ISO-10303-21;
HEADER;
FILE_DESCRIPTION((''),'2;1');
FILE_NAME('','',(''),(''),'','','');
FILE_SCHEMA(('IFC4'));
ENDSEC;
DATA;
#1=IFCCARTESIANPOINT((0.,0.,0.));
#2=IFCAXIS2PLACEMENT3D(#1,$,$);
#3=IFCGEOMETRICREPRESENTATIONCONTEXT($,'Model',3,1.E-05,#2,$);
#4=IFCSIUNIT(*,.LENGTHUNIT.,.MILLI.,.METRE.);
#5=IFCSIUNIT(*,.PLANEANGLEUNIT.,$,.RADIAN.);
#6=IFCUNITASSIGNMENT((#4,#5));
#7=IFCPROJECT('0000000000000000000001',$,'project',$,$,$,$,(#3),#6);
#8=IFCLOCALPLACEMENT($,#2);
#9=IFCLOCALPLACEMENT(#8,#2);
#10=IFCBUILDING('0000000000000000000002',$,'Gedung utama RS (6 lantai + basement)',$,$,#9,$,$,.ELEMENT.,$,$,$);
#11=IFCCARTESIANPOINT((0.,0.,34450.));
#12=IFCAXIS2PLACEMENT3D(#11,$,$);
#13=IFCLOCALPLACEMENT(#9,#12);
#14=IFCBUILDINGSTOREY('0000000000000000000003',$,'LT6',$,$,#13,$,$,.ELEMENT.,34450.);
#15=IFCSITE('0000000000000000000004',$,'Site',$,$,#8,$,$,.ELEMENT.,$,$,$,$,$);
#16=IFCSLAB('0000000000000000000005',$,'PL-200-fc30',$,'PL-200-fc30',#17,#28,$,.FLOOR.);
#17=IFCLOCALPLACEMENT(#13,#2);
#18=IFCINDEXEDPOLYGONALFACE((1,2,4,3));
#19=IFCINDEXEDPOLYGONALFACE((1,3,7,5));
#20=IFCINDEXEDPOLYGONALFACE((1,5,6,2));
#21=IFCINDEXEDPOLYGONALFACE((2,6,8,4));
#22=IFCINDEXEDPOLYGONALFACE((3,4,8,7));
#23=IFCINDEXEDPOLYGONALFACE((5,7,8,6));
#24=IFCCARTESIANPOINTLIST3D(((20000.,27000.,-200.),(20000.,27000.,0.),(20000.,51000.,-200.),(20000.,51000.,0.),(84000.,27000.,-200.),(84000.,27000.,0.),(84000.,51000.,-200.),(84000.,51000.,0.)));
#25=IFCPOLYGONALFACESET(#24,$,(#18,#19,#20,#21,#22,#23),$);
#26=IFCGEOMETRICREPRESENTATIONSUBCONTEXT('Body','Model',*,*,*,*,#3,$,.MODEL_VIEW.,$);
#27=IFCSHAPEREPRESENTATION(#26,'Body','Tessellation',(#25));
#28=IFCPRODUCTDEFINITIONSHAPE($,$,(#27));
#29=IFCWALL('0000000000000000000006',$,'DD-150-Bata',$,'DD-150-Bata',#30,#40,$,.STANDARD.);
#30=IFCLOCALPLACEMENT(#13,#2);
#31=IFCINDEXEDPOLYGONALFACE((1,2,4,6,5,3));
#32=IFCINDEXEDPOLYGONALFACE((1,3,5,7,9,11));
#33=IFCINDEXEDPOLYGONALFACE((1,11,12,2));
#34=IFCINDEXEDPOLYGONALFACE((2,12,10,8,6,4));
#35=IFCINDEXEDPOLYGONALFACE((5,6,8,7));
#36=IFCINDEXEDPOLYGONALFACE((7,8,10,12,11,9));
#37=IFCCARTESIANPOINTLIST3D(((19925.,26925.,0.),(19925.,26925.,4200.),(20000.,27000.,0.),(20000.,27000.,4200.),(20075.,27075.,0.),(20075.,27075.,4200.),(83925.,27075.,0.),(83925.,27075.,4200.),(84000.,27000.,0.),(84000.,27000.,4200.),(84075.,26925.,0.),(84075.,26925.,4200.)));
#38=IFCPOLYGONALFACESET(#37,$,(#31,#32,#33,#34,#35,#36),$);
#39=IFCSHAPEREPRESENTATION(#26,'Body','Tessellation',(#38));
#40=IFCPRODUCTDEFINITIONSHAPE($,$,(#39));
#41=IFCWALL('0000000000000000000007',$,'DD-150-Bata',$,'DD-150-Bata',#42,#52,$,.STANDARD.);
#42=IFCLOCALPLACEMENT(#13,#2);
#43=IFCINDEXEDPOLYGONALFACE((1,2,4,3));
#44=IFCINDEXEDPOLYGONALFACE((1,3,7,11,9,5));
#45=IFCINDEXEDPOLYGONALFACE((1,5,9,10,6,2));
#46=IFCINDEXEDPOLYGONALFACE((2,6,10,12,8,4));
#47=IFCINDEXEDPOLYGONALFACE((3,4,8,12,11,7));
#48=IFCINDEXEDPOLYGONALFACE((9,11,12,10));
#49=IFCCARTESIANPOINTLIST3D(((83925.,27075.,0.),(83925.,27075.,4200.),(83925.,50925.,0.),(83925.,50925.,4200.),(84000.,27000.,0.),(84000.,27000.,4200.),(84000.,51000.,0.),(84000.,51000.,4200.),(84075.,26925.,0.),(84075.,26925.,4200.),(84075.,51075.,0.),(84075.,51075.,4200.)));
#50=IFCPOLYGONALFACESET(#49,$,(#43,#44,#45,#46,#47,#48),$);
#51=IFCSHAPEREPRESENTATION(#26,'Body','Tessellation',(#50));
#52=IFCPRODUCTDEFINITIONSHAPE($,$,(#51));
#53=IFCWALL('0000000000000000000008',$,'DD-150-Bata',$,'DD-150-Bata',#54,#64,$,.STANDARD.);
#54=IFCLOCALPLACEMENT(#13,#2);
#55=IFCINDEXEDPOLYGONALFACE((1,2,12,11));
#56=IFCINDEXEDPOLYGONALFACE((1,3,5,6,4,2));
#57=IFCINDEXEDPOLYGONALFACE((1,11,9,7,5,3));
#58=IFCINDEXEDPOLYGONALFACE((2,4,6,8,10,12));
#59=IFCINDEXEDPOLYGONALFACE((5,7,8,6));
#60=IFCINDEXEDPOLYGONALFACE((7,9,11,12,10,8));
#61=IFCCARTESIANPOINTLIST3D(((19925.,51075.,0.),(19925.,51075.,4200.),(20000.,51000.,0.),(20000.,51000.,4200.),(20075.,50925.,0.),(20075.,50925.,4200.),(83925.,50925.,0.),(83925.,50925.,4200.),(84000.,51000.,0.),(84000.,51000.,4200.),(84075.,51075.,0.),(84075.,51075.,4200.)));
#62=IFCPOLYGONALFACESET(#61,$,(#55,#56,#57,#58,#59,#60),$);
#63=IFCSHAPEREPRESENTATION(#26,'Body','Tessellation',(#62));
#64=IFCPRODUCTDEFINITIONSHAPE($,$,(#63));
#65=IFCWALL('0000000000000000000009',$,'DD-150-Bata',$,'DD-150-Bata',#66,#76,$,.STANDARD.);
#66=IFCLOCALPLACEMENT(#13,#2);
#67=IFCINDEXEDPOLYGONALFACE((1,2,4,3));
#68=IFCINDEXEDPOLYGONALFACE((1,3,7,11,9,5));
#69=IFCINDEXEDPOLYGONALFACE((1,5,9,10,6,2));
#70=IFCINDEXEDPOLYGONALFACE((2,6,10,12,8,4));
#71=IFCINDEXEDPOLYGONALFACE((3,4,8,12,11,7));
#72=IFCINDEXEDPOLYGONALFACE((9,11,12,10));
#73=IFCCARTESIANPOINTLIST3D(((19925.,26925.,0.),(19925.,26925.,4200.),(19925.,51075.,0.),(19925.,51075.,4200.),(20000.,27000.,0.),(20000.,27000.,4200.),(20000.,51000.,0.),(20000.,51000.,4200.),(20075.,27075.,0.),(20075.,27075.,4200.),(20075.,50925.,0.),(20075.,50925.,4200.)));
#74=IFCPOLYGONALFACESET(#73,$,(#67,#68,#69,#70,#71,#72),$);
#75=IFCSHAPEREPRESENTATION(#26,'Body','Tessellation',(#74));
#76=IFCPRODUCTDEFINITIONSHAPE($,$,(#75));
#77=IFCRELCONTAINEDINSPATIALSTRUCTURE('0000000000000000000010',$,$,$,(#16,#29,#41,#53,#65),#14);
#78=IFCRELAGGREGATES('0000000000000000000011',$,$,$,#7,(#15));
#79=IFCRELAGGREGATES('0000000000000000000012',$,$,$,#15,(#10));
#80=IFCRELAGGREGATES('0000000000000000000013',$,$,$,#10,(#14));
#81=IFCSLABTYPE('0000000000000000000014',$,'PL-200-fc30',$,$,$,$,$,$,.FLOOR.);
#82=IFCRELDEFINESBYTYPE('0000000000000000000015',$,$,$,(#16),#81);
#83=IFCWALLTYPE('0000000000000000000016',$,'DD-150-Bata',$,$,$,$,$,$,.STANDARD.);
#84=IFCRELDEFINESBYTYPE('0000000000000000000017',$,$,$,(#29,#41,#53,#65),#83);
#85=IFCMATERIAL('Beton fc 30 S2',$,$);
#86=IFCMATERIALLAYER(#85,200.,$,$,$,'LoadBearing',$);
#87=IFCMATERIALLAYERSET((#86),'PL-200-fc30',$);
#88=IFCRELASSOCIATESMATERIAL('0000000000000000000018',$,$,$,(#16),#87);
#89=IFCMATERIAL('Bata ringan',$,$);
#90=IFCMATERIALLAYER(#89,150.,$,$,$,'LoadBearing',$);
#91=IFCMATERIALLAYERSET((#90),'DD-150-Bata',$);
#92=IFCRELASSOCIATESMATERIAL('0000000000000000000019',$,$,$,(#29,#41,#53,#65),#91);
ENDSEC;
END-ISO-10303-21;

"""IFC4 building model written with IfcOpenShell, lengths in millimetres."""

from ifc_helpers import new_model, si_unit, frame, origin, place, context, subcontext, project, spatial, polyline, outline, extrude, material, layer, layer_set, layer_usage, type_object, element, save


model = new_model("IFC4")

# Units and contexts
model_context = context("Model", 3, precision=1e-05, world=origin())
body_context = subcontext(model_context, "Body", "Model", "MODEL_VIEW")
ifc_project = project(units=[si_unit("LENGTHUNIT", "METRE", prefix="MILLI"), si_unit("PLANEANGLEUNIT", "RADIAN")], contexts=[model_context])

# Site, building, storey
site_placement = place(None, origin())
site = spatial("IfcSite", under=ifc_project, at=site_placement, Name="Site", CompositionType="ELEMENT")
building_placement = place(site_placement, origin())
building = spatial("IfcBuilding", under=site, at=building_placement, Name="Gedung utama RS (6 lantai + basement)", CompositionType="ELEMENT")
storey_placement = place(building_placement, frame((0.0, 0.0, 34450.0)))
storey = spatial("IfcBuildingStorey", under=building, at=storey_placement, Name="LT6", CompositionType="ELEMENT", Elevation=34450.0)

# Slab
ifc_material_1 = material(Name="Beton fc 30 S2")
ifc_layer_1 = layer(ifc_material_1, 200.0, Category="LoadBearing")
ifc_layer_set_1 = layer_set([ifc_layer_1], Name="PL-200-fc30")
ifc_layer_usage_1 = layer_usage(ifc_layer_set_1, "AXIS3", "NEGATIVE", 0.0)
slab_type = type_object("IfcSlabType", Name="PL-200-fc30", PredefinedType="FLOOR")
slab_placement = place(storey_placement, origin())
element("IfcSlab", 1, at=slab_placement, inside=storey, type_object=slab_type, material=ifc_layer_usage_1, Name="PL-200-fc30", ObjectType="PL-200-fc30", PredefinedType="FLOOR", context=body_context, shape_type="SweptSolid", body=[
    extrude(outline(polyline([(20000.0, 27000.0), (84000.0, 27000.0), (84000.0, 51000.0), (20000.0, 51000.0), (20000.0, 27000.0)])), frame((0.0, 0.0, -200.0)), (0.0, 0.0, 1.0), 200.0),
])

# Walls
ifc_material_2 = material(Name="Bata ringan")
ifc_layer_2 = layer(ifc_material_2, 150.0, Category="LoadBearing")
ifc_layer_set_2 = layer_set([ifc_layer_2], Name="DD-150-Bata")
ifc_layer_usage_2 = layer_usage(ifc_layer_set_2, "AXIS2", "NEGATIVE", 75.0)
wall_type = type_object("IfcWallType", Name="DD-150-Bata", PredefinedType="STANDARD")
wall_1_placement = place(storey_placement, frame((20000.0, 27000.0, 0.0), z_axis=(0.0, 0.0, 1.0), x_axis=(1.0, 0.0, 0.0)))
element("IfcWall", 2, at=wall_1_placement, inside=storey, type_object=wall_type, material=ifc_layer_usage_2, Name="DD-150-Bata", ObjectType="DD-150-Bata", PredefinedType="STANDARD", context=body_context, shape_type="SweptSolid", body=[
    extrude(outline(polyline([(-75.0, -75.0), (0.0, 0.0), (75.0, 75.0), (63925.0, 75.0), (64000.0, 0.0), (64075.0, -75.0), (-75.0, -75.0)])), origin(), (0.0, 0.0, 1.0), 4200.0),
])
wall_2_placement = place(storey_placement, frame((84000.0, 27000.0, 0.0), z_axis=(0.0, 0.0, 1.0), x_axis=(0.0, 1.0, 0.0)))
element("IfcWall", 3, at=wall_2_placement, inside=storey, type_object=wall_type, material=ifc_layer_usage_2, Name="DD-150-Bata", ObjectType="DD-150-Bata", PredefinedType="STANDARD", context=body_context, shape_type="SweptSolid", body=[
    extrude(outline(polyline([(-75.0, -75.0), (0.0, 0.0), (75.0, 75.0), (23925.0, 75.0), (24000.0, 0.0), (24075.0, -75.0), (-75.0, -75.0)])), origin(), (0.0, 0.0, 1.0), 4200.0),
])
wall_3_placement = place(storey_placement, frame((84000.0, 51000.0, 0.0), z_axis=(0.0, 0.0, 1.0), x_axis=(-1.0, 0.0, 0.0)))
element("IfcWall", 4, at=wall_3_placement, inside=storey, type_object=wall_type, material=ifc_layer_usage_2, Name="DD-150-Bata", ObjectType="DD-150-Bata", PredefinedType="STANDARD", context=body_context, shape_type="SweptSolid", body=[
    extrude(outline(polyline([(-75.0, -75.0), (0.0, 0.0), (75.0, 75.0), (63925.0, 75.0), (64000.0, 0.0), (64075.0, -75.0), (-75.0, -75.0)])), origin(), (0.0, 0.0, 1.0), 4200.0),
])
wall_4_placement = place(storey_placement, frame((20000.0, 51000.0, 0.0), z_axis=(0.0, 0.0, 1.0), x_axis=(0.0, -1.0, 0.0)))
element("IfcWall", 5, at=wall_4_placement, inside=storey, type_object=wall_type, material=ifc_layer_usage_2, Name="DD-150-Bata", ObjectType="DD-150-Bata", PredefinedType="STANDARD", context=body_context, shape_type="SweptSolid", body=[
    extrude(outline(polyline([(-75.0, -75.0), (0.0, 0.0), (75.0, 75.0), (23925.0, 75.0), (24000.0, 0.0), (24075.0, -75.0), (-75.0, -75.0)])), origin(), (0.0, 0.0, 1.0), 4200.0),
])

save(model, "model.ifc")
